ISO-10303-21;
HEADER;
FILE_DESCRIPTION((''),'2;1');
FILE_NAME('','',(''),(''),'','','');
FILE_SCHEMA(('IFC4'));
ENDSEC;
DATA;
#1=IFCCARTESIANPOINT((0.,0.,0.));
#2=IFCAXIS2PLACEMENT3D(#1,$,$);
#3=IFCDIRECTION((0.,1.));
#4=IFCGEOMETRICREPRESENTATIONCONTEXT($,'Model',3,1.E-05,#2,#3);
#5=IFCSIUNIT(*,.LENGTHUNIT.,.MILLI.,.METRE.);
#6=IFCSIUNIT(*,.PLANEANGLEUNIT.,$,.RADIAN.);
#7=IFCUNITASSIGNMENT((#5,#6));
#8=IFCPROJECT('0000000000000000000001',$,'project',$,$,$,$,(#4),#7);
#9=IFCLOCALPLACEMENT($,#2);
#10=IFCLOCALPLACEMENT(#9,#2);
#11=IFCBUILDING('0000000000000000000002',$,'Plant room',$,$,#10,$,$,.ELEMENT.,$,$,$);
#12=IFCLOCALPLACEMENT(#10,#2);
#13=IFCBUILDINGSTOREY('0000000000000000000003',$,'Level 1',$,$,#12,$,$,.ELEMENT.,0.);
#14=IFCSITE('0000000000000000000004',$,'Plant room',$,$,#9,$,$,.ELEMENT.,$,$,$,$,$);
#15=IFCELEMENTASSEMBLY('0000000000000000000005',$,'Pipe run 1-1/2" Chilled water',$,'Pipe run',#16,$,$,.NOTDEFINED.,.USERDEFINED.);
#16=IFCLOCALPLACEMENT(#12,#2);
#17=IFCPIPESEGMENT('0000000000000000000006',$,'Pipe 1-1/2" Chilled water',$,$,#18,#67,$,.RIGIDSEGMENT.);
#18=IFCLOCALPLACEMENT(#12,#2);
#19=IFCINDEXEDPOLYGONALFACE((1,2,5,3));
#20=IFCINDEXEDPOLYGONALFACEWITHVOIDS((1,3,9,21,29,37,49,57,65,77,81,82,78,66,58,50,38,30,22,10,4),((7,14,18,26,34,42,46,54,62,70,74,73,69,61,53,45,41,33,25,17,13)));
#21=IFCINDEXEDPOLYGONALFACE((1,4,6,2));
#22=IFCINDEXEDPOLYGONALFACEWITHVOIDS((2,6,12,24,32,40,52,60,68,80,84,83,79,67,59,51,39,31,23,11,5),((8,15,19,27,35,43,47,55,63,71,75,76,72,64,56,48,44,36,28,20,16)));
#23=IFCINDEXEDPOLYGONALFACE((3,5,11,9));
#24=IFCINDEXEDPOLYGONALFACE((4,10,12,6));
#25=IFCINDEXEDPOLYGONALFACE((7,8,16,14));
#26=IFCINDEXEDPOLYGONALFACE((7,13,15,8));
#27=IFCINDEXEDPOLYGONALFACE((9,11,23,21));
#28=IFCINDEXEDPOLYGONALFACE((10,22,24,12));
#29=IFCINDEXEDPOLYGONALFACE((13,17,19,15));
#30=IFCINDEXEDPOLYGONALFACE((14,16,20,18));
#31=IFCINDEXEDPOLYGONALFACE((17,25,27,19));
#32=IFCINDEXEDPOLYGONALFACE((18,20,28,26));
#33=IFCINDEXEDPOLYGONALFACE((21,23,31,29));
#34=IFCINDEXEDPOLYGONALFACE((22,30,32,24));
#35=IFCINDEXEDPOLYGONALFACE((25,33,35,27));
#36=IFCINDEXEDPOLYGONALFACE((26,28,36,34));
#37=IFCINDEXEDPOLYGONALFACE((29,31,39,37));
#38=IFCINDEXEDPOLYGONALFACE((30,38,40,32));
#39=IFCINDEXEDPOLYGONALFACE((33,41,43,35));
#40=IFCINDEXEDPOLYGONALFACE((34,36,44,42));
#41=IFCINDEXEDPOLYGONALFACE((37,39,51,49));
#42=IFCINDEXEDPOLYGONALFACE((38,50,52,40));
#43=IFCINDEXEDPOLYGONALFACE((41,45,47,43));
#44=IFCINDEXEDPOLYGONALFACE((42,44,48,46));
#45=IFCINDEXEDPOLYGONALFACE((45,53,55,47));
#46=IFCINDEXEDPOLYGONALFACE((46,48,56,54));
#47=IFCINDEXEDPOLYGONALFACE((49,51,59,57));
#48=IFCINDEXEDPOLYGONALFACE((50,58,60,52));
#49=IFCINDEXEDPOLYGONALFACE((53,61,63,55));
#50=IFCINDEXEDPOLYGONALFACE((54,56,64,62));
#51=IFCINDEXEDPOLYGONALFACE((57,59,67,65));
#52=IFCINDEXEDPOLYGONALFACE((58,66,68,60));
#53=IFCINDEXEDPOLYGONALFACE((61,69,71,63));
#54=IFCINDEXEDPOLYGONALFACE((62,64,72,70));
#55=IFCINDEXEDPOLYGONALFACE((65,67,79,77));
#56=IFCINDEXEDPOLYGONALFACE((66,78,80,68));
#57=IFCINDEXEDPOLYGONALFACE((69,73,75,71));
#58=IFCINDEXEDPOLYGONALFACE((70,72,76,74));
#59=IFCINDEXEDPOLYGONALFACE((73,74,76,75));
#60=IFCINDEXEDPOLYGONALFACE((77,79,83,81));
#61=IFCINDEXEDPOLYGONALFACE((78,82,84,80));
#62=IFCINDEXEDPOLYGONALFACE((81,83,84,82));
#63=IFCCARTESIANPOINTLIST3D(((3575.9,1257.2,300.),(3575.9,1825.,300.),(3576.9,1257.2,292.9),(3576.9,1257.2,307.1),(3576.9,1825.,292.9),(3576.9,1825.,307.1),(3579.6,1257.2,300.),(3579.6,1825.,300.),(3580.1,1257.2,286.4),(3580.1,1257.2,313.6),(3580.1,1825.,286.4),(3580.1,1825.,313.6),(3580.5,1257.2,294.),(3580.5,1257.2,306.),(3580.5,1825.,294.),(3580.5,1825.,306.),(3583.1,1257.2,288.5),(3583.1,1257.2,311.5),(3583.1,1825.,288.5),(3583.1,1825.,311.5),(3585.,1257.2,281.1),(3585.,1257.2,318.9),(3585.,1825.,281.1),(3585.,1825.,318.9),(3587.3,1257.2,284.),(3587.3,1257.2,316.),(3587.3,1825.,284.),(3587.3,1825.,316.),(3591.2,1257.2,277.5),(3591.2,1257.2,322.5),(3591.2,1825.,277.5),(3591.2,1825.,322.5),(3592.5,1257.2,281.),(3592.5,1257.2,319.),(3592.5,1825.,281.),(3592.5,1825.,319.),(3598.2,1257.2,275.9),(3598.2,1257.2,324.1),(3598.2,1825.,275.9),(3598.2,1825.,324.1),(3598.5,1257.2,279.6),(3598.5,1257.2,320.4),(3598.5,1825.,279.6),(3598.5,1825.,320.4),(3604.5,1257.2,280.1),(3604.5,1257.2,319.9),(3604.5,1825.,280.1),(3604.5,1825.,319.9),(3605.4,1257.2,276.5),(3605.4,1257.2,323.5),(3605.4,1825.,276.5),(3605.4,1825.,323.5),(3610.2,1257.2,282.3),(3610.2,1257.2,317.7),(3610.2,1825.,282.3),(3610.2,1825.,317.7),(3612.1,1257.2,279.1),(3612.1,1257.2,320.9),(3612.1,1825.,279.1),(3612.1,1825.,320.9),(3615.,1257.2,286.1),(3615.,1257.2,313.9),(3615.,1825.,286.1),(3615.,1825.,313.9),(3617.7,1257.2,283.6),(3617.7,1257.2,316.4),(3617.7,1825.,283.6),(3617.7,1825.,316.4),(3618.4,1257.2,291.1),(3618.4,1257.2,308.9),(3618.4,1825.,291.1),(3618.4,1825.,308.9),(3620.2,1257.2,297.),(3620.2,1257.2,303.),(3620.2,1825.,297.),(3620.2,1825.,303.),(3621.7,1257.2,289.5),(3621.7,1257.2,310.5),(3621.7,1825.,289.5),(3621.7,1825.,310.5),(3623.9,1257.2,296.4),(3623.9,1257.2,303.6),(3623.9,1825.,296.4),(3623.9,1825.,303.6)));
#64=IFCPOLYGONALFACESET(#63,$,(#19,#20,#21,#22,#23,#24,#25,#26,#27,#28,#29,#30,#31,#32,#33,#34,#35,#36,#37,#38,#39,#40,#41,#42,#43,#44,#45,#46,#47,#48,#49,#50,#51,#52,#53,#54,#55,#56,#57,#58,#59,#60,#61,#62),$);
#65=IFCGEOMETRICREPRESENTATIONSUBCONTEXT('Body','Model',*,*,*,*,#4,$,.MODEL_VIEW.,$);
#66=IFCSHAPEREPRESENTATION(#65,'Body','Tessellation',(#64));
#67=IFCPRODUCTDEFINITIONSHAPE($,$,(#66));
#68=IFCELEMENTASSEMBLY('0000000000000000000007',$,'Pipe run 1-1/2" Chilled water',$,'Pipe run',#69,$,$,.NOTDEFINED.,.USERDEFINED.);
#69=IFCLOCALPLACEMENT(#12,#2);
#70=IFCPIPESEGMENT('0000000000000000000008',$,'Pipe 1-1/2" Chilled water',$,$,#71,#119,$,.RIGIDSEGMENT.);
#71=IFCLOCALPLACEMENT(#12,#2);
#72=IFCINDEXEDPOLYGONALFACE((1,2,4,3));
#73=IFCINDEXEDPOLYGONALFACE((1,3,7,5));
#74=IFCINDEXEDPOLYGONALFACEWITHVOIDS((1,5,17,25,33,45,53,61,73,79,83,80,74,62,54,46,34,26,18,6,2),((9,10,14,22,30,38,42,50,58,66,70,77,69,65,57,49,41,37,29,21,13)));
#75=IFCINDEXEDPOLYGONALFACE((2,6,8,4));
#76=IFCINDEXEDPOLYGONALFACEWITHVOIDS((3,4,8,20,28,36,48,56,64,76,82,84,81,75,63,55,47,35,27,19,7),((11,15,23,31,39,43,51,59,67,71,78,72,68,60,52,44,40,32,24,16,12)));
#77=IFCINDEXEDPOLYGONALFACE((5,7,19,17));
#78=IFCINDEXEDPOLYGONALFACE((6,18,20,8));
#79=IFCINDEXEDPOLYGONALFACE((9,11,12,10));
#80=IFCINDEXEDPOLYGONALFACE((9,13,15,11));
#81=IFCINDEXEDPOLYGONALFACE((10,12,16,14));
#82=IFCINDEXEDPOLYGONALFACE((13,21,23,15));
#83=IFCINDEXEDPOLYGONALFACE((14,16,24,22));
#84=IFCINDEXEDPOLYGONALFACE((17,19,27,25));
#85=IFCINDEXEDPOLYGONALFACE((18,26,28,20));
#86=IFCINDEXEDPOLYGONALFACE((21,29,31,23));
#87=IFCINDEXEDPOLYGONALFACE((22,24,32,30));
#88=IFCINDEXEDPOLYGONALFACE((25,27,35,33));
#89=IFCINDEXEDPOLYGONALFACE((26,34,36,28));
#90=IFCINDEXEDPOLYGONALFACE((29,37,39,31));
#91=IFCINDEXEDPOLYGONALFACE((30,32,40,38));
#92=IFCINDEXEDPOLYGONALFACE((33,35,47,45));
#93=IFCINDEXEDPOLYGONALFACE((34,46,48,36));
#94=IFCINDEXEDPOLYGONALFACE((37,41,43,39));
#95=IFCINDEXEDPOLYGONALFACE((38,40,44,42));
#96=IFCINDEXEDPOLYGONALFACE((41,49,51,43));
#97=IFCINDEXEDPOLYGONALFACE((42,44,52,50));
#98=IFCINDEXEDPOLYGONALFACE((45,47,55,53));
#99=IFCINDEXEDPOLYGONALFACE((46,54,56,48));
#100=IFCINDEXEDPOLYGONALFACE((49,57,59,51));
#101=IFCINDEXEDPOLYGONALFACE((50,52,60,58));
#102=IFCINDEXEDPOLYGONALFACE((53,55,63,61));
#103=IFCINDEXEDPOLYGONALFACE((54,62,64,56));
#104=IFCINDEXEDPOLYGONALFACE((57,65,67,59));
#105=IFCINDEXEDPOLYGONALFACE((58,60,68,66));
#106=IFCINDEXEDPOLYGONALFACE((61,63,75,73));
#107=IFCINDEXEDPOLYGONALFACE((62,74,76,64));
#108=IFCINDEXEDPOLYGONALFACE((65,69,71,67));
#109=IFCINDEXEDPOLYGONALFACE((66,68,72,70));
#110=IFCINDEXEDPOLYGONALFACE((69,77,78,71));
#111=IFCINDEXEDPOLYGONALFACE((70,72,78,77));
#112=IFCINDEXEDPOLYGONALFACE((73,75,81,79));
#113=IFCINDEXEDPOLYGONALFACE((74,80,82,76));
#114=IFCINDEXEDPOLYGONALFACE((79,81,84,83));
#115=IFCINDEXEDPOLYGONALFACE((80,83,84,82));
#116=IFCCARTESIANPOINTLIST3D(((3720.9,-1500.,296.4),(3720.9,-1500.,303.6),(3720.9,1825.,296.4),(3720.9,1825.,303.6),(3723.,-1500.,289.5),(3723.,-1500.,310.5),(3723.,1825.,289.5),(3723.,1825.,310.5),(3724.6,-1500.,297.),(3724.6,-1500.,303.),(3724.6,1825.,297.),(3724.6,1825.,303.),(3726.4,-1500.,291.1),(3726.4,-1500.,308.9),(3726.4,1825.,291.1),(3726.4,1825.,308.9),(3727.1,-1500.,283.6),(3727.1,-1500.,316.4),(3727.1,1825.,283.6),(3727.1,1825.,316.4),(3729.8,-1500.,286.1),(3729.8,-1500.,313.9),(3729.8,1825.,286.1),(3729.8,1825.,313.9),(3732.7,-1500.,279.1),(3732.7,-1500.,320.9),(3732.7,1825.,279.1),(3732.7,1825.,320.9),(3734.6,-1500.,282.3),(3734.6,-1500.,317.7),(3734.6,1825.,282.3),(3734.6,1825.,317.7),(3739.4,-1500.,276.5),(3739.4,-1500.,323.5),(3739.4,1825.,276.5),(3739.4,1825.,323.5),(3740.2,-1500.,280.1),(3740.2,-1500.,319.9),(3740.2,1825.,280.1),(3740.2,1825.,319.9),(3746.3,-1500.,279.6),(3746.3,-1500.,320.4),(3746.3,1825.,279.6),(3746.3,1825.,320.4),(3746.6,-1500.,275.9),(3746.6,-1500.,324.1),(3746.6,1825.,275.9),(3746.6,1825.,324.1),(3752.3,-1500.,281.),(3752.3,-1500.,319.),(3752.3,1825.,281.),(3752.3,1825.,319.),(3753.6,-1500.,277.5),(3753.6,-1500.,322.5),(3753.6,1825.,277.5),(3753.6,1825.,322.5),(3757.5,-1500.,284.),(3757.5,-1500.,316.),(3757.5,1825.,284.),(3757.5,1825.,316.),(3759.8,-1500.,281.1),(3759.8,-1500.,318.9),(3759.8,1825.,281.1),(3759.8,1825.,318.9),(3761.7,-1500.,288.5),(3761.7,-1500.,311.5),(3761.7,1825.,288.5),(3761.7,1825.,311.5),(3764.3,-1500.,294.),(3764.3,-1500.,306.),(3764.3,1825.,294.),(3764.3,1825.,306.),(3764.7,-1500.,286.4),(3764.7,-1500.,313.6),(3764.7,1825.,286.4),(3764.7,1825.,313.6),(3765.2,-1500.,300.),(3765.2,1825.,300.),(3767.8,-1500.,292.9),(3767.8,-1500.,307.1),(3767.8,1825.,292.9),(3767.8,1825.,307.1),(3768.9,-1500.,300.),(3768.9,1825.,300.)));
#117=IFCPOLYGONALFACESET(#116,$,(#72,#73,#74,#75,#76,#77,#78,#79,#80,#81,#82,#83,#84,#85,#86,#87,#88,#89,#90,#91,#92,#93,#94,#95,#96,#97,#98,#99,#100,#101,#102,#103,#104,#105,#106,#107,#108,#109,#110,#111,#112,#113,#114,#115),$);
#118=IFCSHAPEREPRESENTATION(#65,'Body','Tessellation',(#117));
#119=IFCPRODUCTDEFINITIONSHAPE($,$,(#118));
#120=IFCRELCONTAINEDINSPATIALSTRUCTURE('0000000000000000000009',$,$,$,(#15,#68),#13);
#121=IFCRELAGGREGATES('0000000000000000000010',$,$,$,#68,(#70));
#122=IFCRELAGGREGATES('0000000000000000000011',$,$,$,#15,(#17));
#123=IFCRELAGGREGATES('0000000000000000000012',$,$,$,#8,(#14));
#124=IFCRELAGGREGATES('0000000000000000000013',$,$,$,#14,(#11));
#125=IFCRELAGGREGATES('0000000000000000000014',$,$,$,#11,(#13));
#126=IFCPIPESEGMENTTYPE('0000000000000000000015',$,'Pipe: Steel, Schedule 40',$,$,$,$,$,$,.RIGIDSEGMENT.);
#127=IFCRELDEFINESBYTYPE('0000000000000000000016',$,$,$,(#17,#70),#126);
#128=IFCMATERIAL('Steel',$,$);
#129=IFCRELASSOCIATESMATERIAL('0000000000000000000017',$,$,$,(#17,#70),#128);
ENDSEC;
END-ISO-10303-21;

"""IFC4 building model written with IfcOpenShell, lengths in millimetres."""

from ifc_helpers import new_model, si_unit, direction, frame, origin, origin_with_axes, origin_2d, place, context, subcontext, project, spatial, hollow_circle, extrude, material, type_object, element, aggregate, save


model = new_model("IFC4")

# Units and contexts
model_context = context("Model", 3, precision=1e-05, world=origin(), true_north=direction((0.0, 1.0)))
body_context = subcontext(model_context, "Body", "Model", "MODEL_VIEW")
ifc_project = project(units=[si_unit("LENGTHUNIT", "METRE", prefix="MILLI"), si_unit("PLANEANGLEUNIT", "RADIAN")], contexts=[model_context])

# Site, building, storey
site_placement = place(None, origin())
site = spatial("IfcSite", under=ifc_project, at=site_placement, Name="Plant room", CompositionType="ELEMENT")
building_placement = place(site_placement, origin())
building = spatial("IfcBuilding", under=site, at=building_placement, Name="Plant room", CompositionType="ELEMENT")
storey_placement = place(building_placement, origin())
storey = spatial("IfcBuildingStorey", under=building, at=storey_placement, Name="Level 1", CompositionType="ELEMENT", Elevation=0.0)

# Element assembly, pipe segment
assembly_1_placement = place(storey_placement, origin_with_axes())
assembly_1 = element("IfcElementAssembly", 1, at=assembly_1_placement, inside=storey, Name="Pipe run 1-1/2\" Chilled water", ObjectType="Pipe run", AssemblyPlace="NOTDEFINED", PredefinedType="USERDEFINED")
ifc_material_1 = material(Name="Steel")
pipe_segment_type = type_object("IfcPipeSegmentType", Name="Pipe: Steel, Schedule 40", PredefinedType="RIGIDSEGMENT")
pipe_segment_1_placement = place(storey_placement, origin_with_axes())
pipe_segment_1 = element("IfcPipeSegment", 2, at=pipe_segment_1_placement, type_object=pipe_segment_type, material=ifc_material_1, Name="Pipe 1-1/2\" Chilled water", PredefinedType="RIGIDSEGMENT", context=body_context, shape_type="SweptSolid", body=[
    extrude(hollow_circle(Radius=24.1, WallThickness=3.7, at=origin_2d()), frame((3600.0, 1257.2, 300.0), z_axis=(0.0, 1.0, 0.0), x_axis=(-1.0, 0.0, 0.0)), (0.0, 0.0, 1.0), 567.9),
])

# Element assembly, pipe segment
assembly_2_placement = place(storey_placement, origin_with_axes())
assembly_2 = element("IfcElementAssembly", 3, at=assembly_2_placement, inside=storey, Name="Pipe run 1-1/2\" Chilled water", ObjectType="Pipe run", AssemblyPlace="NOTDEFINED", PredefinedType="USERDEFINED")
pipe_segment_2_placement = place(storey_placement, origin_with_axes())
pipe_segment_2 = element("IfcPipeSegment", 4, at=pipe_segment_2_placement, type_object=pipe_segment_type, material=ifc_material_1, Name="Pipe 1-1/2\" Chilled water", PredefinedType="RIGIDSEGMENT", context=body_context, shape_type="SweptSolid", body=[
    extrude(hollow_circle(Radius=24.1, WallThickness=3.7, at=origin_2d()), frame((3744.8, 1825.0, 300.0), z_axis=(0.0, -1.0, 0.0), x_axis=(1.0, 0.0, 0.0)), (0.0, 0.0, 1.0), 3325.0),
])
aggregate(assembly_2, [pipe_segment_2])

aggregate(assembly_1, [pipe_segment_1])

save(model, "model.ifc")
